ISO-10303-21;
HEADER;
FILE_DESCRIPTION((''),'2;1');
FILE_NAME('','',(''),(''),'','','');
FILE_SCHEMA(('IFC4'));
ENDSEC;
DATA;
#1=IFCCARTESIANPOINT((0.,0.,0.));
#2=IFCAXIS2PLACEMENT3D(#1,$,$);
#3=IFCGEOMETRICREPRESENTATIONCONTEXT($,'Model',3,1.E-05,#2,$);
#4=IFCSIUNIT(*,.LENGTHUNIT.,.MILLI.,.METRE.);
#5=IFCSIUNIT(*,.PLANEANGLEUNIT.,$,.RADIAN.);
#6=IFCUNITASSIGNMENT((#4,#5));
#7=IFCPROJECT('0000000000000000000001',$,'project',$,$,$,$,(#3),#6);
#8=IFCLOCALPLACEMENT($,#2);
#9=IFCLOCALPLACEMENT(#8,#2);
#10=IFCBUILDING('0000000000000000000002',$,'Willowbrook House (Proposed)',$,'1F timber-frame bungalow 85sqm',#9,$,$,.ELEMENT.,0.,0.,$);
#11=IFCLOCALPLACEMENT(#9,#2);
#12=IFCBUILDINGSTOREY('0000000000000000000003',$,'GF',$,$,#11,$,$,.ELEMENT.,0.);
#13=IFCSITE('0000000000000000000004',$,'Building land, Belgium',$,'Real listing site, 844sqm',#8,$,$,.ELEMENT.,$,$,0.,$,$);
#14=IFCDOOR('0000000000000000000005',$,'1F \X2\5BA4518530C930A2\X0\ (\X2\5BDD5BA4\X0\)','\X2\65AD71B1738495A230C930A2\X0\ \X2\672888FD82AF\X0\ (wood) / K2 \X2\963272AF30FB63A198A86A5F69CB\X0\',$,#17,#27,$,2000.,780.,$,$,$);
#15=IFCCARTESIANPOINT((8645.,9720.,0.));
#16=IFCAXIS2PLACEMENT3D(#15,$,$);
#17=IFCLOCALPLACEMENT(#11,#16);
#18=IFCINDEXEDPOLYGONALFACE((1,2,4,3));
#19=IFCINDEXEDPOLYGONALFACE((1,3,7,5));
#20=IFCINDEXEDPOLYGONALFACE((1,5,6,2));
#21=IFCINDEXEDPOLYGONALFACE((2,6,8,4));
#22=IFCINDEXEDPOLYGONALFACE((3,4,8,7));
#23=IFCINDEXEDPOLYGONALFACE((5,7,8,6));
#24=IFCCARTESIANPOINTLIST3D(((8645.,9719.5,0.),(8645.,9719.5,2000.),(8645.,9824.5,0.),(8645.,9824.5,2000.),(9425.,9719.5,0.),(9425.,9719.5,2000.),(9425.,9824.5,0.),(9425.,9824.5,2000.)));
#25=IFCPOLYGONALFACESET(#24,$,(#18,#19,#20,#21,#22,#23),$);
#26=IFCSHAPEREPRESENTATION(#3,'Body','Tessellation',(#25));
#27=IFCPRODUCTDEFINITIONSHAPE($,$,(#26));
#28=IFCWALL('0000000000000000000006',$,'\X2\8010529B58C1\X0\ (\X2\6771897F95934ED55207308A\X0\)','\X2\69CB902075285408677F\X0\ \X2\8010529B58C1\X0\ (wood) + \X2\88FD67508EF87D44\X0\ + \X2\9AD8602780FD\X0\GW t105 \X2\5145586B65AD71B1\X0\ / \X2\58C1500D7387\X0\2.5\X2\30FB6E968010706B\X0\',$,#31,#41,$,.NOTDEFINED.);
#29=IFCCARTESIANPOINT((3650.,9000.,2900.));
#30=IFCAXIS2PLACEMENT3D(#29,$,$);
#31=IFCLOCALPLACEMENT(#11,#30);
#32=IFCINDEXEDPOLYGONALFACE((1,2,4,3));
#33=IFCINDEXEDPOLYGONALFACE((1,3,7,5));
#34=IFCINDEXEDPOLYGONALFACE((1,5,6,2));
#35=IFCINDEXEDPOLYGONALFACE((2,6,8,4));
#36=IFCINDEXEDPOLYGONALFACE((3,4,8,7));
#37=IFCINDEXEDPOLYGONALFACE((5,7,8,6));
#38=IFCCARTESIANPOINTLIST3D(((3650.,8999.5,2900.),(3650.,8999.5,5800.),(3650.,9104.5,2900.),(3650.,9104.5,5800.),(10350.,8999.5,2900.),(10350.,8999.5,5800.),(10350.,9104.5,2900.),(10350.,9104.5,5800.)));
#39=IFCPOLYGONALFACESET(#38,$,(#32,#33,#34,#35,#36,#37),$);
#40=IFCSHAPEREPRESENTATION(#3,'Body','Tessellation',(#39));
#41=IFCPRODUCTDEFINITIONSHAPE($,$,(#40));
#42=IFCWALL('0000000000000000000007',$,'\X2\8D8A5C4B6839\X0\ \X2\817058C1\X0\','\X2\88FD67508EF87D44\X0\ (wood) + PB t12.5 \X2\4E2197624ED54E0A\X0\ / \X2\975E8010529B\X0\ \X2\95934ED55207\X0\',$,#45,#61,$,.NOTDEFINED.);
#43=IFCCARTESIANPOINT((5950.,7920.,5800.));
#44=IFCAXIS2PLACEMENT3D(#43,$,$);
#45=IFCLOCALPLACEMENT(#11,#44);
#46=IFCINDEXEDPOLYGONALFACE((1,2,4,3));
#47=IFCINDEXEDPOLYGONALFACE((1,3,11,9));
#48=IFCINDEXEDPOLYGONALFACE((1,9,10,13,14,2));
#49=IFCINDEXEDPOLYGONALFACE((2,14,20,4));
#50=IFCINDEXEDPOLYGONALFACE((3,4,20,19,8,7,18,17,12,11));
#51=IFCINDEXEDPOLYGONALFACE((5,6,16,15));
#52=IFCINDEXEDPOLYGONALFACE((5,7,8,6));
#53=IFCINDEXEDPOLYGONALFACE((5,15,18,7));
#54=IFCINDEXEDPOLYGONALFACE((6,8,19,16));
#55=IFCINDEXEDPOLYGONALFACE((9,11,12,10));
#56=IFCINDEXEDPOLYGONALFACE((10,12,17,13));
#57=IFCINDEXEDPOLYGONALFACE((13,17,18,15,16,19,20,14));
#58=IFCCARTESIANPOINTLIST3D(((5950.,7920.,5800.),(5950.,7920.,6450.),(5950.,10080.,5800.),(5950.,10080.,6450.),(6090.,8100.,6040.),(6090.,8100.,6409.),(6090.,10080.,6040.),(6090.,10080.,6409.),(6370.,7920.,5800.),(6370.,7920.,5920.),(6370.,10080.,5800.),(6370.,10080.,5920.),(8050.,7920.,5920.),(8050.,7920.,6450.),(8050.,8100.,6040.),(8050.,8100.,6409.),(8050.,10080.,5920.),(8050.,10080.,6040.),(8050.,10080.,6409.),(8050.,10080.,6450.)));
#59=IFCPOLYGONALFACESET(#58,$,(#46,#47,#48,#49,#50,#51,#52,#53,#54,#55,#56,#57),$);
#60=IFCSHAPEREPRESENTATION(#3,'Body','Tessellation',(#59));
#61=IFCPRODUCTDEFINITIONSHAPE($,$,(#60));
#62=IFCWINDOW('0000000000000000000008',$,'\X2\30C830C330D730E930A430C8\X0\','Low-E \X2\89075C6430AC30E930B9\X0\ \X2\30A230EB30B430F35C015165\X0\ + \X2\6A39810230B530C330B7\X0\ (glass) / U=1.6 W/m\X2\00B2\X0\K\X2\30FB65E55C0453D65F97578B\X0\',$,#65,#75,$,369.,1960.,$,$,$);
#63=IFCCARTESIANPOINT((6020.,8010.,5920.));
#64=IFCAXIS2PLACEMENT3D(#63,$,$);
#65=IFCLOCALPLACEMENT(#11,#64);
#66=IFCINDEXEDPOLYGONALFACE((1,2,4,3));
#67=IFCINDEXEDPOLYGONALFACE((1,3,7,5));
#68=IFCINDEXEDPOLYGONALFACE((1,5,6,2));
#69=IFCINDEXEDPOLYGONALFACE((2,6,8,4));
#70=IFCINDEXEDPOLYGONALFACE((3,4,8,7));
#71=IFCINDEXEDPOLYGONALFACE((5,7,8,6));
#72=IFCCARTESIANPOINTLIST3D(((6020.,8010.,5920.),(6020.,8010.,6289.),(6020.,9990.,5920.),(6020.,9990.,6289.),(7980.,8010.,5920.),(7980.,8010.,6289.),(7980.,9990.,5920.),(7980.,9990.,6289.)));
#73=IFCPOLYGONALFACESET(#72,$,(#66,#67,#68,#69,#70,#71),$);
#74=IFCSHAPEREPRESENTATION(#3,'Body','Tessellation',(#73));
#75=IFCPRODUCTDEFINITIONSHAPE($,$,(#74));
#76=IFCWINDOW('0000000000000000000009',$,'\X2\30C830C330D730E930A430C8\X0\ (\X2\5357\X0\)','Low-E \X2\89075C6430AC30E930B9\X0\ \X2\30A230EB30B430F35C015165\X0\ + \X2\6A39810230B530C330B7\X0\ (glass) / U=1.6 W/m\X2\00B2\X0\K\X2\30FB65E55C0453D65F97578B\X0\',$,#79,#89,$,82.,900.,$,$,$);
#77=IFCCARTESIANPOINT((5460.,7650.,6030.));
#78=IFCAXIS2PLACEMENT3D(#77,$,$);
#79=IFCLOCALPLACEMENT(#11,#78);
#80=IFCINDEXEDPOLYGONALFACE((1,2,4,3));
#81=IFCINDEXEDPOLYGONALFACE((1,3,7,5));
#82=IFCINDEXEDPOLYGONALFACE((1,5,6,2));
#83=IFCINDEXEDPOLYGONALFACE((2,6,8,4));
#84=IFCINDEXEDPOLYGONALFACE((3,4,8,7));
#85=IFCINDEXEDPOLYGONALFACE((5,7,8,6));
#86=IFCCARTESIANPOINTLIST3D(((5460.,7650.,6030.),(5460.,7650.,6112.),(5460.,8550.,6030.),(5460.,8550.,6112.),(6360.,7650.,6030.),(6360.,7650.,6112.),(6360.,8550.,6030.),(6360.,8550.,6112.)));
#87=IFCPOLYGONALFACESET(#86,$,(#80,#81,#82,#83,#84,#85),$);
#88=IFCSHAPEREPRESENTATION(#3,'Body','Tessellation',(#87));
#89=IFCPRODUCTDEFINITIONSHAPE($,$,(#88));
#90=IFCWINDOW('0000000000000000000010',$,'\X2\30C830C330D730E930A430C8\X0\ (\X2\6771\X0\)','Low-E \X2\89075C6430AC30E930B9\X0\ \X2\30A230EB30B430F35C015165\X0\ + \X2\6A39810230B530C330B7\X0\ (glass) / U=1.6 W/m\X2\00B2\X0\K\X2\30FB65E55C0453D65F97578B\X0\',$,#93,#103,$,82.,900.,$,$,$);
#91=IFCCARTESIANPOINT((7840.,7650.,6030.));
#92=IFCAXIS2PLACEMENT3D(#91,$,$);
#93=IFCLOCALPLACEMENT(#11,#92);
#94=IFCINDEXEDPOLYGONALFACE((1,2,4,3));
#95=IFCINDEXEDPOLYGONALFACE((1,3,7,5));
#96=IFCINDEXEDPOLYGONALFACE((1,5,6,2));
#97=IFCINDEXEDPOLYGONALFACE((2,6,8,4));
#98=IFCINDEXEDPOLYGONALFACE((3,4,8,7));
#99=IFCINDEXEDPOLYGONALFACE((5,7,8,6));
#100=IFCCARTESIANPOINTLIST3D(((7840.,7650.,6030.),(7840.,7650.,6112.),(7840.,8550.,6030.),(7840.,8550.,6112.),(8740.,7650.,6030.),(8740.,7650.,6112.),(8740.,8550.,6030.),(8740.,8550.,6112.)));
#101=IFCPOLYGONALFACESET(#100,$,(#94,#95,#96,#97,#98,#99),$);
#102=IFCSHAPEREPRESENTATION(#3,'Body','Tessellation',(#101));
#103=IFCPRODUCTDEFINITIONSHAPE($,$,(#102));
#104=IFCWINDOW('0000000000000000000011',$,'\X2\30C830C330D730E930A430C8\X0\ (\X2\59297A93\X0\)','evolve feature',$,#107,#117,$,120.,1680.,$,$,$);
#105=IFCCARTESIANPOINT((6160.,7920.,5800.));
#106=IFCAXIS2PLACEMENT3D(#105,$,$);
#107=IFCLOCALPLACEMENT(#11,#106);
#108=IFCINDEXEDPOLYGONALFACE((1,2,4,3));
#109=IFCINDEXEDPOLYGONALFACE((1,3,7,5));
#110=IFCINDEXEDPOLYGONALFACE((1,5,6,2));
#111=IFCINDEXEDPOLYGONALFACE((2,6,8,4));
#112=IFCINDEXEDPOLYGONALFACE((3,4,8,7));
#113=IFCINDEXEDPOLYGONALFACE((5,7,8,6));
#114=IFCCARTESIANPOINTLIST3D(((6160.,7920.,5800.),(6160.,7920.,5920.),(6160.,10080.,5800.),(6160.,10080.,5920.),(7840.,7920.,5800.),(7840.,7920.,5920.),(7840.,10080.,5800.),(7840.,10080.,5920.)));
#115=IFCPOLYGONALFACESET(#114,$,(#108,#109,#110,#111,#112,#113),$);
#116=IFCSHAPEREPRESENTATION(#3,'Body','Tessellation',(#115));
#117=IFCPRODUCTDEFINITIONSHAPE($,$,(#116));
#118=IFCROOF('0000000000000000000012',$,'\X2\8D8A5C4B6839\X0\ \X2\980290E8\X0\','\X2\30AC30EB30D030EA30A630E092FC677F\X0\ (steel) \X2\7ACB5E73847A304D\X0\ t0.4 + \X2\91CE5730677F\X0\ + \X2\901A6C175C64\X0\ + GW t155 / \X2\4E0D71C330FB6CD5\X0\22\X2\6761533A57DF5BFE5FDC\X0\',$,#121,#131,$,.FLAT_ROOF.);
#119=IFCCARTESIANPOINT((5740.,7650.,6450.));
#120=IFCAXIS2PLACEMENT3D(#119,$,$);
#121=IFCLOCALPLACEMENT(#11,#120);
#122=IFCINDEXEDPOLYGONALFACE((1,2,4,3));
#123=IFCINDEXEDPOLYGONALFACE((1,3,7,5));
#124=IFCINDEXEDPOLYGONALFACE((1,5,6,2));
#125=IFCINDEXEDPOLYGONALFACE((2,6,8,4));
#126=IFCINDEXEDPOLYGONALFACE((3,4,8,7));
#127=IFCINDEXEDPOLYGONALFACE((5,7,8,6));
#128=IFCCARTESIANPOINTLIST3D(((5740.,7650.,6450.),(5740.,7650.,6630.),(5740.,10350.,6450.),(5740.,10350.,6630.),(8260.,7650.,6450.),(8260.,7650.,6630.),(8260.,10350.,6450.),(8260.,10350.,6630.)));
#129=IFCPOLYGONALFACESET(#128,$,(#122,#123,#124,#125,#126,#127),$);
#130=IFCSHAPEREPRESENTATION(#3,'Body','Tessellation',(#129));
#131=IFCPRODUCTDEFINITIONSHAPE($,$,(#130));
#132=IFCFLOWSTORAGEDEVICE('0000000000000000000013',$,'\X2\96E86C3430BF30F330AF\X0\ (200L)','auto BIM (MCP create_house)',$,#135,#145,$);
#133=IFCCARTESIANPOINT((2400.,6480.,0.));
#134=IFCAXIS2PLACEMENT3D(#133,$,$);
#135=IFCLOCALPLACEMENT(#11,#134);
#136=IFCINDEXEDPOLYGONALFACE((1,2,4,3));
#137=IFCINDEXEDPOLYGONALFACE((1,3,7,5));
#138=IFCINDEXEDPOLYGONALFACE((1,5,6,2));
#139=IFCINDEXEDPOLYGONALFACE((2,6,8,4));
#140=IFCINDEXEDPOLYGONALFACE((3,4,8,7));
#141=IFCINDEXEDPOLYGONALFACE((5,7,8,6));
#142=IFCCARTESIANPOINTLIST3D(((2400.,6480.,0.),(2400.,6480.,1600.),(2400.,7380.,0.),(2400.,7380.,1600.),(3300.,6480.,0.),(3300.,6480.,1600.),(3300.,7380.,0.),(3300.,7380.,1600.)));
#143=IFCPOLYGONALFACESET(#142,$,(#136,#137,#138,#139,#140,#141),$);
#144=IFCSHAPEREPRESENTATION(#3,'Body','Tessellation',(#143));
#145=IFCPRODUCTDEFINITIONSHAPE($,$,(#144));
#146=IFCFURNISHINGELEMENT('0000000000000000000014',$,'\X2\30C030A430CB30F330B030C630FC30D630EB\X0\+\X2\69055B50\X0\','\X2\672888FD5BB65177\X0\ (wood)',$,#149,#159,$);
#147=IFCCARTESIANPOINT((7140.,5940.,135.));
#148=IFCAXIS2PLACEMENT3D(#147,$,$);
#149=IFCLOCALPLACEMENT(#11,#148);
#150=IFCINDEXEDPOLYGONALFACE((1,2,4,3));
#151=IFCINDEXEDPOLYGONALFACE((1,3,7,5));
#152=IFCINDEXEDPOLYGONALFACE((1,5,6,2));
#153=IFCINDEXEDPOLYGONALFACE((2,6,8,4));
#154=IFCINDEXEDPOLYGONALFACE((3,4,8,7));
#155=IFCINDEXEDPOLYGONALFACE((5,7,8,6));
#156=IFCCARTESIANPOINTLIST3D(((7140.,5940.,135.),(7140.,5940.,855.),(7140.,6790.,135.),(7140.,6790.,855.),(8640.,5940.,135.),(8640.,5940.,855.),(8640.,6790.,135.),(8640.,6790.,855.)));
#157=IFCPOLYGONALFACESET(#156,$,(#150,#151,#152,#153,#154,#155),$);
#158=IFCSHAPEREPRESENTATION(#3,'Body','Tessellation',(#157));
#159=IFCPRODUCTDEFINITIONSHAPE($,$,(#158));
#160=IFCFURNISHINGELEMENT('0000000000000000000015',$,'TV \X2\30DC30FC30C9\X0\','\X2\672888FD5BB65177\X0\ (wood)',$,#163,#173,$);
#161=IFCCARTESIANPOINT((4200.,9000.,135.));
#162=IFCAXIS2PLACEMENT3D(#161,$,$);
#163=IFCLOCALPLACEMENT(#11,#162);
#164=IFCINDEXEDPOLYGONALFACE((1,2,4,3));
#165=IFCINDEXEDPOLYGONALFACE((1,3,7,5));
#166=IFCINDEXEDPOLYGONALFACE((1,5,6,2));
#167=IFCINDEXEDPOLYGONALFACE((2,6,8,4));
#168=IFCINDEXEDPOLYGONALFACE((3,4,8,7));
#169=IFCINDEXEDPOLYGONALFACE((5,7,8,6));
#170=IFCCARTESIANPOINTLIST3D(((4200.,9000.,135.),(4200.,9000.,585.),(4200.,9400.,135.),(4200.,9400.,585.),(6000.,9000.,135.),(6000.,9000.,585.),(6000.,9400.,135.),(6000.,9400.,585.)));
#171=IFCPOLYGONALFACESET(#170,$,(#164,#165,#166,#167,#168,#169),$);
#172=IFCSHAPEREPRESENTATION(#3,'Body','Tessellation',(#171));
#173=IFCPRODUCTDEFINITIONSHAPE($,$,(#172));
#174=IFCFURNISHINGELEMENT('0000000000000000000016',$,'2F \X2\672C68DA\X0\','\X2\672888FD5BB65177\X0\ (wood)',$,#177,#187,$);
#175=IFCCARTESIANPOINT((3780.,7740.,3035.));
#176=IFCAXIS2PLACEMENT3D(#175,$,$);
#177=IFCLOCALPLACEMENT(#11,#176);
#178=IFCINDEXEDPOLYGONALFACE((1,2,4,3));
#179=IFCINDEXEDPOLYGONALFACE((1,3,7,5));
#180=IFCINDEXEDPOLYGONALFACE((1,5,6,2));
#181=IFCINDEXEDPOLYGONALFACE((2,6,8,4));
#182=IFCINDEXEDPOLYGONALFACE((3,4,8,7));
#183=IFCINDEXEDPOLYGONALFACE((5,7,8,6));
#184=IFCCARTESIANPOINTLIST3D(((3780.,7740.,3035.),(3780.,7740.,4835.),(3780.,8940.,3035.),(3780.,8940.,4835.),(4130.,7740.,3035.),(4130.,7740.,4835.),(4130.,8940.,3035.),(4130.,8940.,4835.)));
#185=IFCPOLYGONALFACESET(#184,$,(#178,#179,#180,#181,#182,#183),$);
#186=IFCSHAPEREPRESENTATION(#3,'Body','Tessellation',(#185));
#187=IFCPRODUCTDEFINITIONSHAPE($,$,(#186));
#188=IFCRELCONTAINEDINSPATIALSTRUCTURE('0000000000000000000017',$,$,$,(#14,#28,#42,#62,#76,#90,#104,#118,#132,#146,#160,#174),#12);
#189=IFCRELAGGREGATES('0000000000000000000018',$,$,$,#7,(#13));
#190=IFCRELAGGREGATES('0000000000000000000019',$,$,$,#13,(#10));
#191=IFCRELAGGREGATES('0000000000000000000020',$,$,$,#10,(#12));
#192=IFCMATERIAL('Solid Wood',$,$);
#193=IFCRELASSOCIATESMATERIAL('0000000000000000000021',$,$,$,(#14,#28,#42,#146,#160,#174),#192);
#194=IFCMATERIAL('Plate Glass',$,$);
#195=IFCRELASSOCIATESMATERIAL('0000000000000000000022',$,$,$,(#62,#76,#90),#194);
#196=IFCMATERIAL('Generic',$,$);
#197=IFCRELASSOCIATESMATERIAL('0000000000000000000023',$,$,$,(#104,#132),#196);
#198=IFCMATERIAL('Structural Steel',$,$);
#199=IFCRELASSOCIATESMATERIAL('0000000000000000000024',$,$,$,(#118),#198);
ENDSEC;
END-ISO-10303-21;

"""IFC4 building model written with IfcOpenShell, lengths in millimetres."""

from ifc_helpers import new_model, si_unit, frame, frame_2d, origin, place, context, project, spatial, rectangle, extrude, material, element, fill, save


model = new_model("IFC4")

# Units and contexts
model_context = context("Model", 3, precision=1e-05, world=origin())
ifc_project = project(units=[si_unit("LENGTHUNIT", "METRE", prefix="MILLI"), si_unit("PLANEANGLEUNIT", "RADIAN")], contexts=[model_context])

# Site, building, storey
site_placement = place(None, origin())
site = spatial("IfcSite", under=ifc_project, at=site_placement, Name="Building land, Belgium", ObjectType="Real listing site, 844sqm", CompositionType="ELEMENT", RefElevation=0.0)
building_placement = place(site_placement, origin())
building = spatial("IfcBuilding", under=site, at=building_placement, Name="Willowbrook House (Proposed)", ObjectType="1F timber-frame bungalow 85sqm", CompositionType="ELEMENT", ElevationOfRefHeight=0.0, ElevationOfTerrain=0.0)
storey_placement = place(building_placement, origin())
storey = spatial("IfcBuildingStorey", under=building, at=storey_placement, Name="GF", CompositionType="ELEMENT", Elevation=0.0)

# Shared definitions
ifc_material_1 = material(Name="Solid Wood")

# Door
door_placement = place(storey_placement, frame((8645.0, 9720.0, 0.0)))
element("IfcDoor", 1, at=door_placement, inside=storey, material=ifc_material_1, Name="1F 室内ドア (寝室)", Description="断熱玄関ドア 木製芯 (wood) / K2 防犯・採風機構", OverallHeight=2000.0, OverallWidth=780.0, context=model_context, shape_type="SweptSolid", body=[
    extrude(rectangle(XDim=780.0, YDim=105.0, at=frame_2d((390.0, 52.0))), frame((8645.0, 9720.0, 0.0)), (0.0, 0.0, 1.0), 2000.0),
])

# Wall
wall_1_placement = place(storey_placement, frame((3650.0, 9000.0, 2900.0)))
element("IfcWall", 2, at=wall_1_placement, inside=storey, material=ifc_material_1, Name="耐力壁 (東西間仕切り)", Description="構造用合板 耐力壁 (wood) + 製材軸組 + 高性能GW t105 充填断熱 / 壁倍率2.5・準耐火", PredefinedType="NOTDEFINED", context=model_context, shape_type="SweptSolid", body=[
    extrude(rectangle(XDim=6700.0, YDim=105.0, at=frame_2d((3350.0, 52.0))), frame((3650.0, 9000.0, 2900.0)), (0.0, 0.0, 1.0), 2900.0),
])

# Wall, openings, windows
wall_2_placement = place(storey_placement, frame((5950.0, 7920.0, 5800.0)))
wall_2 = element("IfcWall", 3, at=wall_2_placement, inside=storey, material=ifc_material_1, Name="越屋根 腰壁", Description="製材軸組 (wood) + PB t12.5 両面仕上 / 非耐力 間仕切", PredefinedType="NOTDEFINED", context=model_context, shape_type="SweptSolid", body=[
    extrude(rectangle(XDim=2100.0, YDim=2160.0, at=frame_2d((1050.0, 1080.0))), frame((5950.0, 7920.0, 5800.0)), (0.0, 0.0, 1.0), 650.0),
])
opening_1_placement = place(storey_placement, frame((6020.0, 8010.0, 5920.0)))
opening_1 = element("IfcOpeningElement", 4, at=opening_1_placement, cuts=wall_2, PredefinedType="NOTDEFINED", context=model_context, shape_type="SweptSolid", body=[
    extrude(rectangle(XDim=1960.0, YDim=1980.0, at=frame_2d((980.0, 990.0))), frame((6020.0, 8010.0, 5920.0)), (0.0, 0.0, 1.0), 369.0),
])
opening_2_placement = place(storey_placement, frame((5460.0, 7650.0, 6030.0)))
opening_2 = element("IfcOpeningElement", 5, at=opening_2_placement, cuts=wall_2, PredefinedType="NOTDEFINED", context=model_context, shape_type="SweptSolid", body=[
    extrude(rectangle(XDim=900.0, YDim=900.0, at=frame_2d((450.0, 450.0))), frame((5460.0, 7650.0, 6030.0)), (0.0, 0.0, 1.0), 82.0),
])
opening_3_placement = place(storey_placement, frame((7840.0, 7650.0, 6030.0)))
opening_3 = element("IfcOpeningElement", 6, at=opening_3_placement, cuts=wall_2, PredefinedType="NOTDEFINED", context=model_context, shape_type="SweptSolid", body=[
    extrude(rectangle(XDim=900.0, YDim=900.0, at=frame_2d((450.0, 450.0))), frame((7840.0, 7650.0, 6030.0)), (0.0, 0.0, 1.0), 82.0),
])
opening_4_placement = place(storey_placement, frame((6160.0, 7920.0, 5800.0)))
opening_4 = element("IfcOpeningElement", 7, at=opening_4_placement, cuts=wall_2, PredefinedType="NOTDEFINED", context=model_context, shape_type="SweptSolid", body=[
    extrude(rectangle(XDim=1680.0, YDim=2160.0, at=frame_2d((840.0, 1080.0))), frame((6160.0, 7920.0, 5800.0)), (0.0, 0.0, 1.0), 120.0),
])
ifc_material_2 = material(Name="Plate Glass")
window_1_placement = place(storey_placement, frame((6020.0, 8010.0, 5920.0)))
window_1 = element("IfcWindow", 8, at=window_1_placement, inside=storey, material=ifc_material_2, Name="トップライト", Description="Low-E 複層ガラス アルゴン封入 + 樹脂サッシ (glass) / U=1.6 W/m²K・日射取得型", OverallHeight=369.0, OverallWidth=1960.0, context=model_context, shape_type="SweptSolid", body=[
    extrude(rectangle(XDim=1960.0, YDim=1980.0, at=frame_2d((980.0, 990.0))), frame((6020.0, 8010.0, 5920.0)), (0.0, 0.0, 1.0), 369.0),
])
fill(opening_1, window_1)
window_2_placement = place(storey_placement, frame((5460.0, 7650.0, 6030.0)))
window_2 = element("IfcWindow", 9, at=window_2_placement, inside=storey, material=ifc_material_2, Name="トップライト (南)", Description="Low-E 複層ガラス アルゴン封入 + 樹脂サッシ (glass) / U=1.6 W/m²K・日射取得型", OverallHeight=82.0, OverallWidth=900.0, context=model_context, shape_type="SweptSolid", body=[
    extrude(rectangle(XDim=900.0, YDim=900.0, at=frame_2d((450.0, 450.0))), frame((5460.0, 7650.0, 6030.0)), (0.0, 0.0, 1.0), 82.0),
])
fill(opening_2, window_2)
window_3_placement = place(storey_placement, frame((7840.0, 7650.0, 6030.0)))
window_3 = element("IfcWindow", 10, at=window_3_placement, inside=storey, material=ifc_material_2, Name="トップライト (東)", Description="Low-E 複層ガラス アルゴン封入 + 樹脂サッシ (glass) / U=1.6 W/m²K・日射取得型", OverallHeight=82.0, OverallWidth=900.0, context=model_context, shape_type="SweptSolid", body=[
    extrude(rectangle(XDim=900.0, YDim=900.0, at=frame_2d((450.0, 450.0))), frame((7840.0, 7650.0, 6030.0)), (0.0, 0.0, 1.0), 82.0),
])
fill(opening_3, window_3)
ifc_material_3 = material(Name="Generic")
window_4_placement = place(storey_placement, frame((6160.0, 7920.0, 5800.0)))
window_4 = element("IfcWindow", 11, at=window_4_placement, inside=storey, material=ifc_material_3, Name="トップライト (天窓)", Description="evolve feature", OverallHeight=120.0, OverallWidth=1680.0, context=model_context, shape_type="SweptSolid", body=[
    extrude(rectangle(XDim=1680.0, YDim=2160.0, at=frame_2d((840.0, 1080.0))), frame((6160.0, 7920.0, 5800.0)), (0.0, 0.0, 1.0), 120.0),
])
fill(opening_4, window_4)

# Roof
ifc_material_4 = material(Name="Structural Steel")
roof_placement = place(storey_placement, frame((5740.0, 7650.0, 6450.0)))
element("IfcRoof", 12, at=roof_placement, inside=storey, material=ifc_material_4, Name="越屋根 頂部", Description="ガルバリウム鋼板 (steel) 立平葺き t0.4 + 野地板 + 通気層 + GW t155 / 不燃・法22条区域対応", PredefinedType="FLAT_ROOF", context=model_context, shape_type="SweptSolid", body=[
    extrude(rectangle(XDim=2520.0, YDim=2700.0, at=frame_2d((1260.0, 1350.0))), frame((5740.0, 7650.0, 6450.0)), (0.0, 0.0, 1.0), 180.0),
])

# Flow storage device
flow_storage_device_placement = place(storey_placement, frame((2400.0, 6480.0, 0.0)))
element("IfcFlowStorageDevice", 13, at=flow_storage_device_placement, inside=storey, material=ifc_material_3, Name="雨水タンク (200L)", Description="auto BIM (MCP create_house)", context=model_context, shape_type="SweptSolid", body=[
    extrude(rectangle(XDim=900.0, YDim=900.0, at=frame_2d((450.0, 450.0))), frame((2400.0, 6480.0, 0.0)), (0.0, 0.0, 1.0), 1600.0),
])

# Furnishing elements
furnishing_1_placement = place(storey_placement, frame((7140.0, 5940.0, 135.0)))
element("IfcFurnishingElement", 14, at=furnishing_1_placement, inside=storey, material=ifc_material_1, Name="ダイニングテーブル+椅子", Description="木製家具 (wood)", context=model_context, shape_type="SweptSolid", body=[
    extrude(rectangle(XDim=1500.0, YDim=850.0, at=frame_2d((750.0, 425.0))), frame((7140.0, 5940.0, 135.0)), (0.0, 0.0, 1.0), 720.0),
])
furnishing_2_placement = place(storey_placement, frame((4200.0, 9000.0, 135.0)))
element("IfcFurnishingElement", 15, at=furnishing_2_placement, inside=storey, material=ifc_material_1, Name="TV ボード", Description="木製家具 (wood)", context=model_context, shape_type="SweptSolid", body=[
    extrude(rectangle(XDim=1800.0, YDim=400.0, at=frame_2d((900.0, 200.0))), frame((4200.0, 9000.0, 135.0)), (0.0, 0.0, 1.0), 450.0),
])
furnishing_3_placement = place(storey_placement, frame((3780.0, 7740.0, 3035.0)))
element("IfcFurnishingElement", 16, at=furnishing_3_placement, inside=storey, material=ifc_material_1, Name="2F 本棚", Description="木製家具 (wood)", context=model_context, shape_type="SweptSolid", body=[
    extrude(rectangle(XDim=350.0, YDim=1200.0, at=frame_2d((175.0, 600.0))), frame((3780.0, 7740.0, 3035.0)), (0.0, 0.0, 1.0), 1800.0),
])

save(model, "model.ifc")
